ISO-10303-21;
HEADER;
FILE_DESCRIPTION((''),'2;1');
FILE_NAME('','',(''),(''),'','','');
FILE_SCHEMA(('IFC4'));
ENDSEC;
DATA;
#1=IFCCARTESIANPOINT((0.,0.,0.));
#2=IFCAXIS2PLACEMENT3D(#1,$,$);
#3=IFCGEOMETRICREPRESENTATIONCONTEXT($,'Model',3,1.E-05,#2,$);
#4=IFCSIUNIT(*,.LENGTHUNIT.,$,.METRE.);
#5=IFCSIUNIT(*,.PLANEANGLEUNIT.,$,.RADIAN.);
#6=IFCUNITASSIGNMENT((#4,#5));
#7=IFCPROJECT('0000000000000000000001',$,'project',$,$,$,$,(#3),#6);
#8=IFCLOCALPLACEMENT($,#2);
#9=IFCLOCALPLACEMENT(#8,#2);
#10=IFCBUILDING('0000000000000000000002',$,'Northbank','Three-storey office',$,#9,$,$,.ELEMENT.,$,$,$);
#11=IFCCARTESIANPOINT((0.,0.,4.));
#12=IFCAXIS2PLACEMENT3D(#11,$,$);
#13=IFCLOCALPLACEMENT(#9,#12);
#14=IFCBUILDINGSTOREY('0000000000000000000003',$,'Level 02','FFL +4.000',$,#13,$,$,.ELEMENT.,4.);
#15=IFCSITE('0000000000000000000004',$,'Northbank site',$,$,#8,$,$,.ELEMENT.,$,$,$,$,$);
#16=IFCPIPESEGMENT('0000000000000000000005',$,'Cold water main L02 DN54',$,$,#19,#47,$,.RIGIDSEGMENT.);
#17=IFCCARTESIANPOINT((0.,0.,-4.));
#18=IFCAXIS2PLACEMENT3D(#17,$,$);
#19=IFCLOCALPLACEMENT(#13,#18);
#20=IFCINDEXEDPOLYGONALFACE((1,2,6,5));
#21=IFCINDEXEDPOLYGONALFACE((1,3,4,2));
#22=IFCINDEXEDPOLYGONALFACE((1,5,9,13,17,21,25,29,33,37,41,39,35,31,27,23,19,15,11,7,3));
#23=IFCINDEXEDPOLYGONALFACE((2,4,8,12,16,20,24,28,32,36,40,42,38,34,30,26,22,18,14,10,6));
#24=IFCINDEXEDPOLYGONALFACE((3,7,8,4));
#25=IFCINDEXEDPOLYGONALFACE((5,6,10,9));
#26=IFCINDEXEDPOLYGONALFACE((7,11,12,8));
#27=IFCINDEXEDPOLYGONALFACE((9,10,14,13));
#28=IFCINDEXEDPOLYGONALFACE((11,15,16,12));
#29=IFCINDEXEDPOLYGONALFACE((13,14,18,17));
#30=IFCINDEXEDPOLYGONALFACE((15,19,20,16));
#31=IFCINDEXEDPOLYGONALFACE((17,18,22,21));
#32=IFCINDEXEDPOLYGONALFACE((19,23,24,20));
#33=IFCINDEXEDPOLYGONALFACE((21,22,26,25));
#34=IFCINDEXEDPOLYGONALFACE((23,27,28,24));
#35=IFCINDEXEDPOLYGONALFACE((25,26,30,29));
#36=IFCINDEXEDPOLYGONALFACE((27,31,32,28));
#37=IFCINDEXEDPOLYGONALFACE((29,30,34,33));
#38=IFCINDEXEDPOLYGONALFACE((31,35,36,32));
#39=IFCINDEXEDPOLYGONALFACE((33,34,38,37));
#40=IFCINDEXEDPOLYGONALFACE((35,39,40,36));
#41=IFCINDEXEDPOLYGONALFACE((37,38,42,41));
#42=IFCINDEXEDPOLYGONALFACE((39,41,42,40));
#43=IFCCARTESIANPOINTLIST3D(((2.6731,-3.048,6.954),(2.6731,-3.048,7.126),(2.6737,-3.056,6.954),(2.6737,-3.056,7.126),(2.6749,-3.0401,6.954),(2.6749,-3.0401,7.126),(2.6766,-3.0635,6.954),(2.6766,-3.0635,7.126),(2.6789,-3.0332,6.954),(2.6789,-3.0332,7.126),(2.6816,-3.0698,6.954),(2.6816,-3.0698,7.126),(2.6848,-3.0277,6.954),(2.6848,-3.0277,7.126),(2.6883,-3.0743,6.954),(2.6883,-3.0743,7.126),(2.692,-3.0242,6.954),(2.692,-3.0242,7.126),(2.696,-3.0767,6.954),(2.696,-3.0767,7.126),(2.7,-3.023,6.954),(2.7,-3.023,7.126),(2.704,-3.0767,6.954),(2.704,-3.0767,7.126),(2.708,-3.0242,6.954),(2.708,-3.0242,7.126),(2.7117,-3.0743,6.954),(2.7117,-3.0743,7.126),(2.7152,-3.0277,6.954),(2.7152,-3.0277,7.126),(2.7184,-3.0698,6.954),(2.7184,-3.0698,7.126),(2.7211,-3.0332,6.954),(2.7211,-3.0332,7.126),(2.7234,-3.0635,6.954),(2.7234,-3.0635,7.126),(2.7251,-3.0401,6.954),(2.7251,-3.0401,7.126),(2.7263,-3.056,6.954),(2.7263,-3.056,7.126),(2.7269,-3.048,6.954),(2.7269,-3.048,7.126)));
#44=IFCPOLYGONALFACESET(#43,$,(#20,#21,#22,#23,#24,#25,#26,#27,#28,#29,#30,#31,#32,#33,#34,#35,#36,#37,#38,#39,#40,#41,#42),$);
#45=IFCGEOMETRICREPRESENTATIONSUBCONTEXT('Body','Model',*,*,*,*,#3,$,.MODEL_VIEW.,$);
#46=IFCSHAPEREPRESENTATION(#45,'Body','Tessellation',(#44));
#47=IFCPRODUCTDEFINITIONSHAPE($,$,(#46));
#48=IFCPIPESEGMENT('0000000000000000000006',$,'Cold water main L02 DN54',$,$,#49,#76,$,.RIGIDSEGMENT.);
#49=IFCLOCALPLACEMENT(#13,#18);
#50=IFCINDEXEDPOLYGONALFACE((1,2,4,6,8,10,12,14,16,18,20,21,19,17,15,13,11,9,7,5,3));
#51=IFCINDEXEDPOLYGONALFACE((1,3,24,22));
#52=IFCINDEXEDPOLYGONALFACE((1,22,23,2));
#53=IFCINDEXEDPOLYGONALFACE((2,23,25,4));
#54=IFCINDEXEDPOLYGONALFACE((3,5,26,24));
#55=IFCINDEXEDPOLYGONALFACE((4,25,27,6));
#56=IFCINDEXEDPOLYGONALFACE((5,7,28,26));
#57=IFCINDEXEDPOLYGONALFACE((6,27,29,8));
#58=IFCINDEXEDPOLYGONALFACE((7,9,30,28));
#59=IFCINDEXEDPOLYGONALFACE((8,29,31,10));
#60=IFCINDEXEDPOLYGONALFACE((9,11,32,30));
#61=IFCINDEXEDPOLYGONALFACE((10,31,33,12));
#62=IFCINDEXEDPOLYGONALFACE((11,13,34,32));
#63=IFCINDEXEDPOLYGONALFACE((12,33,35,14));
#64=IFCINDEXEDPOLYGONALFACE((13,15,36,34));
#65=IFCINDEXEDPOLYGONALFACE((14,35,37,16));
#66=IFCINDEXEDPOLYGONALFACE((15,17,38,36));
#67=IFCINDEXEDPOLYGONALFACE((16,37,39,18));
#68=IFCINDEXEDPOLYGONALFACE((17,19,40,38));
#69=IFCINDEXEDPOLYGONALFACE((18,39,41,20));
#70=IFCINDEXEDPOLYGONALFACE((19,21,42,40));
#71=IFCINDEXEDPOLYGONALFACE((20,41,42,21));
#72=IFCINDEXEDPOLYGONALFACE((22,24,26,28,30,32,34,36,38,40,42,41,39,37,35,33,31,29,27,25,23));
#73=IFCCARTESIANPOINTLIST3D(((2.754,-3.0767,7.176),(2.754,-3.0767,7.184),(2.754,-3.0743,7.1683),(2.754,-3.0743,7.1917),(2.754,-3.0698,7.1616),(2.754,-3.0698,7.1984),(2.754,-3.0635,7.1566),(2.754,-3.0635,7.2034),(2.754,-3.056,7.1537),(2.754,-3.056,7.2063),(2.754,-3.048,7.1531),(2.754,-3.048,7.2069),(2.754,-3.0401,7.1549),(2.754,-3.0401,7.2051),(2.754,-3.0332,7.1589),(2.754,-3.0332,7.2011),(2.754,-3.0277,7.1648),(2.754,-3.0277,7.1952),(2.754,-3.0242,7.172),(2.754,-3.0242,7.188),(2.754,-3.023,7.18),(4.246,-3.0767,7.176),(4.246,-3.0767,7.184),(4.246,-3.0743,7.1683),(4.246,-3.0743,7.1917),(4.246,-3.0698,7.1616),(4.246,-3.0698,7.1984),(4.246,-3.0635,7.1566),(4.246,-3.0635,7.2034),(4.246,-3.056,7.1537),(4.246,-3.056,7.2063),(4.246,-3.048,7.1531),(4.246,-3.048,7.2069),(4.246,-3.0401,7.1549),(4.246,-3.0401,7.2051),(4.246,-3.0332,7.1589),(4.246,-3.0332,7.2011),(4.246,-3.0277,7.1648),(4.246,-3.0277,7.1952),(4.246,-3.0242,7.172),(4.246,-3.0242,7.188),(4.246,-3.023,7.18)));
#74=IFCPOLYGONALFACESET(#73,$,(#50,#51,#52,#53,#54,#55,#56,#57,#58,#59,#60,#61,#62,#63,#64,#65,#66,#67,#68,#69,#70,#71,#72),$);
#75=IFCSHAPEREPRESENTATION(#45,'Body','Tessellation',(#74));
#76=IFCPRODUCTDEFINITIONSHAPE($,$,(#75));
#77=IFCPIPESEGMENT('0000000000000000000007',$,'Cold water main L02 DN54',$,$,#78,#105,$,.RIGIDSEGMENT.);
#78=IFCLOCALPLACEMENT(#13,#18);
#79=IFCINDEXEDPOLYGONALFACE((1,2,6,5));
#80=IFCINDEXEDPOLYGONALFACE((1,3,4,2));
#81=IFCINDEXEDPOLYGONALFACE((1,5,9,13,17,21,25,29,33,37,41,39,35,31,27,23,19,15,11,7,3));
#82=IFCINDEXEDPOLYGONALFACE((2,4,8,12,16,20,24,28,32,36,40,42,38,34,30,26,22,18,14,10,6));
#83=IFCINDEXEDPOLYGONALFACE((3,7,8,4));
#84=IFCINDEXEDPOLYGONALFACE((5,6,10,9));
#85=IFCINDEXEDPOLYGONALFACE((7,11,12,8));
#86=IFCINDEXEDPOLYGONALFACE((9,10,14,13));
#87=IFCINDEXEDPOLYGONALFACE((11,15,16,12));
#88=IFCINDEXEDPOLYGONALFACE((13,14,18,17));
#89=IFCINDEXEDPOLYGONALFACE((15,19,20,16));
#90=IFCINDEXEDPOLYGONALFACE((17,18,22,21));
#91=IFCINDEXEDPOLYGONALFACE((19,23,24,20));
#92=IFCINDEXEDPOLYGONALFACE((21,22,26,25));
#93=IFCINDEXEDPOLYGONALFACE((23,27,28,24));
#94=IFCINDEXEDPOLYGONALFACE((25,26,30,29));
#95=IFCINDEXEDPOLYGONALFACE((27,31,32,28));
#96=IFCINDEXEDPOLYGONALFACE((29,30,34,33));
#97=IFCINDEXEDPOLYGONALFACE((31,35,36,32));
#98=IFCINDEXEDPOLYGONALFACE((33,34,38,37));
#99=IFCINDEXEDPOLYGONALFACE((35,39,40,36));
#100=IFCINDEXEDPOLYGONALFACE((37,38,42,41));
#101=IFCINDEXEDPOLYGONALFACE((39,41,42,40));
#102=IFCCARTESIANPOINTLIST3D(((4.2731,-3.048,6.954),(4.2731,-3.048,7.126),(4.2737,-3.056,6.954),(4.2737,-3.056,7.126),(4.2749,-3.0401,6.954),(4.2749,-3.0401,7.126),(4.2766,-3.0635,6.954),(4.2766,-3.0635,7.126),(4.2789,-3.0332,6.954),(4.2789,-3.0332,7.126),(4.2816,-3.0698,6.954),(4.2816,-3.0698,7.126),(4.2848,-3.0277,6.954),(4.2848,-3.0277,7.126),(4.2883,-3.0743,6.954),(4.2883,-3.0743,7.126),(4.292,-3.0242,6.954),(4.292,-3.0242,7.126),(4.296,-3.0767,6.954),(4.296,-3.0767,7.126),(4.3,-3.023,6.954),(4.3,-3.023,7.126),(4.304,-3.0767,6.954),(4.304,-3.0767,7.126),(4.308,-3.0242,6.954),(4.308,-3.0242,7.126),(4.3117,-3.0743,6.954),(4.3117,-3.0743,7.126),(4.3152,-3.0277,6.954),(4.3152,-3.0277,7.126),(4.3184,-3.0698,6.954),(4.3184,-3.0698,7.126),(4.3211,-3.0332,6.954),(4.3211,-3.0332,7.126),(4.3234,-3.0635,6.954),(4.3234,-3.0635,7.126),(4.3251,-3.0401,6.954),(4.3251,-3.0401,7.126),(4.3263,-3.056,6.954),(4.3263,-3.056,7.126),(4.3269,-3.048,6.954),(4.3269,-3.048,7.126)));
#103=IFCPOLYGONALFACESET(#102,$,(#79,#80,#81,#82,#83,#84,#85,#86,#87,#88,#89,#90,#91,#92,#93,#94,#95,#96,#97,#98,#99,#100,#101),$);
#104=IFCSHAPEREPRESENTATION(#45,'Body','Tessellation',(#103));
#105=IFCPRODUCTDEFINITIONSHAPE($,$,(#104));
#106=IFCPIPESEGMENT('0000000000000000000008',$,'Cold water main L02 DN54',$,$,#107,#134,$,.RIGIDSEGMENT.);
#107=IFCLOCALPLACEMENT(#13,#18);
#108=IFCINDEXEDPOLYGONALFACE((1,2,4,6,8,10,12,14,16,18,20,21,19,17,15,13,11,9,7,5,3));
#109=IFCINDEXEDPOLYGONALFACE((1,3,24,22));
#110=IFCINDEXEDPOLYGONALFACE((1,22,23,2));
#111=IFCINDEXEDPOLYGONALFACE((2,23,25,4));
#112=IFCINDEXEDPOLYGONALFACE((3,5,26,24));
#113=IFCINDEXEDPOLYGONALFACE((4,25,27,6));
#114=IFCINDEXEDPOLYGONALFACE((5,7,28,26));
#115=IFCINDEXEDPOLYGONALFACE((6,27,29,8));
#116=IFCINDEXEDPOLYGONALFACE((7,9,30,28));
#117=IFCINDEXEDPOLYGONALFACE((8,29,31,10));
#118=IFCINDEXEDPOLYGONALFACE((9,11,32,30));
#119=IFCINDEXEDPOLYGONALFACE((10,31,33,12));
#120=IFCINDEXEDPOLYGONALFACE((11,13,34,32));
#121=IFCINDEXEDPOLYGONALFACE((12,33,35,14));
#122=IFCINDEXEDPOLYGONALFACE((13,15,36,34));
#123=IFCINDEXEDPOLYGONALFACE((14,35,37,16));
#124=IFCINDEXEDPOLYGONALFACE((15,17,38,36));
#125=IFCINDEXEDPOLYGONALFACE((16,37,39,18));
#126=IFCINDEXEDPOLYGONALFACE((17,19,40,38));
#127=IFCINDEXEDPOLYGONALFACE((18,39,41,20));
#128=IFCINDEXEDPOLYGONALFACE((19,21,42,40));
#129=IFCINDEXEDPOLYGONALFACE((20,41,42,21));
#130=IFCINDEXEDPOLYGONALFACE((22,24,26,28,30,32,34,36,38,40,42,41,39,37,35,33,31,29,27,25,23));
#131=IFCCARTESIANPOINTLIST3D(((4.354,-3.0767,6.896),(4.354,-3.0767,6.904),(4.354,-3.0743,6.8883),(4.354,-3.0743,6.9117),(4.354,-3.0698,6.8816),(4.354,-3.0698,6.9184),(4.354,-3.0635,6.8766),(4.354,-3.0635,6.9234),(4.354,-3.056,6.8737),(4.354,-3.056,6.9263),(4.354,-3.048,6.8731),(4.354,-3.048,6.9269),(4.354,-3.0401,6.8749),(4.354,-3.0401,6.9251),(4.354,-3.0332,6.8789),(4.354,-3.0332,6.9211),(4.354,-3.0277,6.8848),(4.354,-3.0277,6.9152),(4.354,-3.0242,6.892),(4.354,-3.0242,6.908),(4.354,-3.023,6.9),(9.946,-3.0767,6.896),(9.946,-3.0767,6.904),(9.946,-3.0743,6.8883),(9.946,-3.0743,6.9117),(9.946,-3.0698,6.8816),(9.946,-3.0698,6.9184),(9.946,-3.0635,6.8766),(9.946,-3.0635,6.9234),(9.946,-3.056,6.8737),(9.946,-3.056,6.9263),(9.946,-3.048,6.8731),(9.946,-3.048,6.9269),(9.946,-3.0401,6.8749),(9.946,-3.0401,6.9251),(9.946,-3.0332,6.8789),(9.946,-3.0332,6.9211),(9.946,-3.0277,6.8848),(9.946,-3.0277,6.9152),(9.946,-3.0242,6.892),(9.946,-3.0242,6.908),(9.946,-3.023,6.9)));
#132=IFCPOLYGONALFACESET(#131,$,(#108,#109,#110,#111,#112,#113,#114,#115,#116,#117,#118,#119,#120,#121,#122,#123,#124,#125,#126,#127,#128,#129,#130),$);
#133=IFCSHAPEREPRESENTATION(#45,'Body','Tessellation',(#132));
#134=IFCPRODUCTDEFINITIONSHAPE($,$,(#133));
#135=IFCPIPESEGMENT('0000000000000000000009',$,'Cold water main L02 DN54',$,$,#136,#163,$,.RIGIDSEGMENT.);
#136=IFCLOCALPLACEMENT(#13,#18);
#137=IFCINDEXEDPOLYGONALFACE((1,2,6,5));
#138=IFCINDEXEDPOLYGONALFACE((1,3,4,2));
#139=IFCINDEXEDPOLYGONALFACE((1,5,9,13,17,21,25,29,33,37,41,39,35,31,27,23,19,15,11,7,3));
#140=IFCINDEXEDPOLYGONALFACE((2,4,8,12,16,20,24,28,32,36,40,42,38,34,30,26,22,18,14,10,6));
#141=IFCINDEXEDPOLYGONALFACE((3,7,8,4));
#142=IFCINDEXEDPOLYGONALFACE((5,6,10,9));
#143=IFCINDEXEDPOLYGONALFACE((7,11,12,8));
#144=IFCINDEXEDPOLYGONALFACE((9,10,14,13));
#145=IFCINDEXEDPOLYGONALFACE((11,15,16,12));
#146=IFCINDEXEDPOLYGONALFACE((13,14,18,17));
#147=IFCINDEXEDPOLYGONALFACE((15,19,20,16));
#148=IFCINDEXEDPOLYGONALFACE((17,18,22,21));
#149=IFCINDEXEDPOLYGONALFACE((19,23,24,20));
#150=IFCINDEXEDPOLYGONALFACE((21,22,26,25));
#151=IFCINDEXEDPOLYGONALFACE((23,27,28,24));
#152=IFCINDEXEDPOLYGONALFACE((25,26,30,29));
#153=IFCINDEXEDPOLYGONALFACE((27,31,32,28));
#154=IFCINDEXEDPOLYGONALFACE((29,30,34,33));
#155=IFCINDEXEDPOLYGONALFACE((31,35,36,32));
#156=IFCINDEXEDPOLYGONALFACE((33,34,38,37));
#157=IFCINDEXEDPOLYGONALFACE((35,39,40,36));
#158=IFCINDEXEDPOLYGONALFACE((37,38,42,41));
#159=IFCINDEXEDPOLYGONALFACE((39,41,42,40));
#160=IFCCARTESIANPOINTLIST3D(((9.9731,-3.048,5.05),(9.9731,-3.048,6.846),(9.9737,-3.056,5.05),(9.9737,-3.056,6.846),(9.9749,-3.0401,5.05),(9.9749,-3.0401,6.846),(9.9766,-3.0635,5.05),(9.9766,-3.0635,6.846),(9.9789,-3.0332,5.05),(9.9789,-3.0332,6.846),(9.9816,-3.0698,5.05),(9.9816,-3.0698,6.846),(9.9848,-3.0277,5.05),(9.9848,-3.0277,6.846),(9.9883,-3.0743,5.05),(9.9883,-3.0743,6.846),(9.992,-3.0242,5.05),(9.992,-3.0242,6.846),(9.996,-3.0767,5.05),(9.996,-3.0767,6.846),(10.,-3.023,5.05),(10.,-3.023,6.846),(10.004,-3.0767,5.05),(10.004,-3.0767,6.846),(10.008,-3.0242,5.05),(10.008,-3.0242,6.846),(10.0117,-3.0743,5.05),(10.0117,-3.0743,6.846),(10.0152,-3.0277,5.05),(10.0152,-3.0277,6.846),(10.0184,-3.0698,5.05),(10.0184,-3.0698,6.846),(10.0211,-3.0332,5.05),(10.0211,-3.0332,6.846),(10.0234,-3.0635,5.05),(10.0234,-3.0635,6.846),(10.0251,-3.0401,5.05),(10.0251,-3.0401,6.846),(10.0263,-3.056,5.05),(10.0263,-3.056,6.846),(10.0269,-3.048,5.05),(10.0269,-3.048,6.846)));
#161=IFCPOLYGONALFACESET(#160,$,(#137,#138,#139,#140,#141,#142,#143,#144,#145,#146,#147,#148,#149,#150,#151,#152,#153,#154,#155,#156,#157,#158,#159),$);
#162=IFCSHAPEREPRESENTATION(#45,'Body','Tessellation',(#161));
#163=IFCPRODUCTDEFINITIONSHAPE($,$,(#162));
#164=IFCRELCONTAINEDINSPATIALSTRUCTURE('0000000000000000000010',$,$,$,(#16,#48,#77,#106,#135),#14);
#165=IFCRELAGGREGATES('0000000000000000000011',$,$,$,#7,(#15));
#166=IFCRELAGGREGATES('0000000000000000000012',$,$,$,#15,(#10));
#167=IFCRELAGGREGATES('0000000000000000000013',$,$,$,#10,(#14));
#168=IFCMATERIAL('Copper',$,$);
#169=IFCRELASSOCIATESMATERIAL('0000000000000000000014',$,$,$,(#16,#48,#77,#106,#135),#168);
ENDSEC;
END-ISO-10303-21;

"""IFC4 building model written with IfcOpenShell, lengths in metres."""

from ifc_helpers import new_model, si_unit, frame, origin, place, context, subcontext, project, spatial, circle, extrude, material, element, save


model = new_model("IFC4")

# Units and contexts
model_context = context("Model", 3, precision=1e-05, world=origin())
body_context = subcontext(model_context, "Body", "Model", "MODEL_VIEW")
ifc_project = project(units=[si_unit("LENGTHUNIT", "METRE"), si_unit("PLANEANGLEUNIT", "RADIAN")], contexts=[model_context])

# Site, building, storey
site_placement = place(None, origin())
site = spatial("IfcSite", under=ifc_project, at=site_placement, Name="Northbank site", CompositionType="ELEMENT")
building_placement = place(site_placement, origin())
building = spatial("IfcBuilding", under=site, at=building_placement, Name="Northbank", Description="Three-storey office", CompositionType="ELEMENT")
storey_placement = place(building_placement, frame((0.0, 0.0, 4.0)))
storey = spatial("IfcBuildingStorey", under=building, at=storey_placement, Name="Level 02", Description="FFL +4.000", CompositionType="ELEMENT", Elevation=4.0)

# Shared definitions
ifc_material = material(Name="Copper")

# Pipe segments
pipe_segment_1_placement = place(storey_placement, frame((0.0, 0.0, -4.0)))
element("IfcPipeSegment", 1, at=pipe_segment_1_placement, inside=storey, material=ifc_material, Name="Cold water main L02 DN54", PredefinedType="RIGIDSEGMENT", context=body_context, shape_type="SweptSolid", body=[
    extrude(circle(Radius=0.027), frame((2.7, -3.05, 6.954), z_axis=(0.0, 0.0, 1.0), x_axis=(0.0, 1.0, 0.0)), (0.0, 0.0, 1.0), 0.172),
])
pipe_segment_2_placement = place(storey_placement, frame((0.0, 0.0, -4.0)))
element("IfcPipeSegment", 2, at=pipe_segment_2_placement, inside=storey, material=ifc_material, Name="Cold water main L02 DN54", PredefinedType="RIGIDSEGMENT", context=body_context, shape_type="SweptSolid", body=[
    extrude(circle(Radius=0.027), frame((2.754, -3.05, 7.18), z_axis=(1.0, 0.0, 0.0), x_axis=(0.0, 1.0, 0.0)), (0.0, 0.0, 1.0), 1.492),
])
pipe_segment_3_placement = place(storey_placement, frame((0.0, 0.0, -4.0)))
element("IfcPipeSegment", 3, at=pipe_segment_3_placement, inside=storey, material=ifc_material, Name="Cold water main L02 DN54", PredefinedType="RIGIDSEGMENT", context=body_context, shape_type="SweptSolid", body=[
    extrude(circle(Radius=0.027), frame((4.3, -3.05, 7.126), z_axis=(0.0, 0.0, -1.0), x_axis=(0.0, 1.0, 0.0)), (0.0, 0.0, 1.0), 0.172),
])
pipe_segment_4_placement = place(storey_placement, frame((0.0, 0.0, -4.0)))
element("IfcPipeSegment", 4, at=pipe_segment_4_placement, inside=storey, material=ifc_material, Name="Cold water main L02 DN54", PredefinedType="RIGIDSEGMENT", context=body_context, shape_type="SweptSolid", body=[
    extrude(circle(Radius=0.027), frame((4.354, -3.05, 6.9), z_axis=(1.0, 0.0, 0.0), x_axis=(0.0, 1.0, 0.0)), (0.0, 0.0, 1.0), 5.592),
])
pipe_segment_5_placement = place(storey_placement, frame((0.0, 0.0, -4.0)))
element("IfcPipeSegment", 5, at=pipe_segment_5_placement, inside=storey, material=ifc_material, Name="Cold water main L02 DN54", PredefinedType="RIGIDSEGMENT", context=body_context, shape_type="SweptSolid", body=[
    extrude(circle(Radius=0.027), frame((10.0, -3.05, 6.846), z_axis=(0.0, 0.0, -1.0), x_axis=(0.0, 1.0, 0.0)), (0.0, 0.0, 1.0), 1.796),
])

save(model, "model.ifc")
